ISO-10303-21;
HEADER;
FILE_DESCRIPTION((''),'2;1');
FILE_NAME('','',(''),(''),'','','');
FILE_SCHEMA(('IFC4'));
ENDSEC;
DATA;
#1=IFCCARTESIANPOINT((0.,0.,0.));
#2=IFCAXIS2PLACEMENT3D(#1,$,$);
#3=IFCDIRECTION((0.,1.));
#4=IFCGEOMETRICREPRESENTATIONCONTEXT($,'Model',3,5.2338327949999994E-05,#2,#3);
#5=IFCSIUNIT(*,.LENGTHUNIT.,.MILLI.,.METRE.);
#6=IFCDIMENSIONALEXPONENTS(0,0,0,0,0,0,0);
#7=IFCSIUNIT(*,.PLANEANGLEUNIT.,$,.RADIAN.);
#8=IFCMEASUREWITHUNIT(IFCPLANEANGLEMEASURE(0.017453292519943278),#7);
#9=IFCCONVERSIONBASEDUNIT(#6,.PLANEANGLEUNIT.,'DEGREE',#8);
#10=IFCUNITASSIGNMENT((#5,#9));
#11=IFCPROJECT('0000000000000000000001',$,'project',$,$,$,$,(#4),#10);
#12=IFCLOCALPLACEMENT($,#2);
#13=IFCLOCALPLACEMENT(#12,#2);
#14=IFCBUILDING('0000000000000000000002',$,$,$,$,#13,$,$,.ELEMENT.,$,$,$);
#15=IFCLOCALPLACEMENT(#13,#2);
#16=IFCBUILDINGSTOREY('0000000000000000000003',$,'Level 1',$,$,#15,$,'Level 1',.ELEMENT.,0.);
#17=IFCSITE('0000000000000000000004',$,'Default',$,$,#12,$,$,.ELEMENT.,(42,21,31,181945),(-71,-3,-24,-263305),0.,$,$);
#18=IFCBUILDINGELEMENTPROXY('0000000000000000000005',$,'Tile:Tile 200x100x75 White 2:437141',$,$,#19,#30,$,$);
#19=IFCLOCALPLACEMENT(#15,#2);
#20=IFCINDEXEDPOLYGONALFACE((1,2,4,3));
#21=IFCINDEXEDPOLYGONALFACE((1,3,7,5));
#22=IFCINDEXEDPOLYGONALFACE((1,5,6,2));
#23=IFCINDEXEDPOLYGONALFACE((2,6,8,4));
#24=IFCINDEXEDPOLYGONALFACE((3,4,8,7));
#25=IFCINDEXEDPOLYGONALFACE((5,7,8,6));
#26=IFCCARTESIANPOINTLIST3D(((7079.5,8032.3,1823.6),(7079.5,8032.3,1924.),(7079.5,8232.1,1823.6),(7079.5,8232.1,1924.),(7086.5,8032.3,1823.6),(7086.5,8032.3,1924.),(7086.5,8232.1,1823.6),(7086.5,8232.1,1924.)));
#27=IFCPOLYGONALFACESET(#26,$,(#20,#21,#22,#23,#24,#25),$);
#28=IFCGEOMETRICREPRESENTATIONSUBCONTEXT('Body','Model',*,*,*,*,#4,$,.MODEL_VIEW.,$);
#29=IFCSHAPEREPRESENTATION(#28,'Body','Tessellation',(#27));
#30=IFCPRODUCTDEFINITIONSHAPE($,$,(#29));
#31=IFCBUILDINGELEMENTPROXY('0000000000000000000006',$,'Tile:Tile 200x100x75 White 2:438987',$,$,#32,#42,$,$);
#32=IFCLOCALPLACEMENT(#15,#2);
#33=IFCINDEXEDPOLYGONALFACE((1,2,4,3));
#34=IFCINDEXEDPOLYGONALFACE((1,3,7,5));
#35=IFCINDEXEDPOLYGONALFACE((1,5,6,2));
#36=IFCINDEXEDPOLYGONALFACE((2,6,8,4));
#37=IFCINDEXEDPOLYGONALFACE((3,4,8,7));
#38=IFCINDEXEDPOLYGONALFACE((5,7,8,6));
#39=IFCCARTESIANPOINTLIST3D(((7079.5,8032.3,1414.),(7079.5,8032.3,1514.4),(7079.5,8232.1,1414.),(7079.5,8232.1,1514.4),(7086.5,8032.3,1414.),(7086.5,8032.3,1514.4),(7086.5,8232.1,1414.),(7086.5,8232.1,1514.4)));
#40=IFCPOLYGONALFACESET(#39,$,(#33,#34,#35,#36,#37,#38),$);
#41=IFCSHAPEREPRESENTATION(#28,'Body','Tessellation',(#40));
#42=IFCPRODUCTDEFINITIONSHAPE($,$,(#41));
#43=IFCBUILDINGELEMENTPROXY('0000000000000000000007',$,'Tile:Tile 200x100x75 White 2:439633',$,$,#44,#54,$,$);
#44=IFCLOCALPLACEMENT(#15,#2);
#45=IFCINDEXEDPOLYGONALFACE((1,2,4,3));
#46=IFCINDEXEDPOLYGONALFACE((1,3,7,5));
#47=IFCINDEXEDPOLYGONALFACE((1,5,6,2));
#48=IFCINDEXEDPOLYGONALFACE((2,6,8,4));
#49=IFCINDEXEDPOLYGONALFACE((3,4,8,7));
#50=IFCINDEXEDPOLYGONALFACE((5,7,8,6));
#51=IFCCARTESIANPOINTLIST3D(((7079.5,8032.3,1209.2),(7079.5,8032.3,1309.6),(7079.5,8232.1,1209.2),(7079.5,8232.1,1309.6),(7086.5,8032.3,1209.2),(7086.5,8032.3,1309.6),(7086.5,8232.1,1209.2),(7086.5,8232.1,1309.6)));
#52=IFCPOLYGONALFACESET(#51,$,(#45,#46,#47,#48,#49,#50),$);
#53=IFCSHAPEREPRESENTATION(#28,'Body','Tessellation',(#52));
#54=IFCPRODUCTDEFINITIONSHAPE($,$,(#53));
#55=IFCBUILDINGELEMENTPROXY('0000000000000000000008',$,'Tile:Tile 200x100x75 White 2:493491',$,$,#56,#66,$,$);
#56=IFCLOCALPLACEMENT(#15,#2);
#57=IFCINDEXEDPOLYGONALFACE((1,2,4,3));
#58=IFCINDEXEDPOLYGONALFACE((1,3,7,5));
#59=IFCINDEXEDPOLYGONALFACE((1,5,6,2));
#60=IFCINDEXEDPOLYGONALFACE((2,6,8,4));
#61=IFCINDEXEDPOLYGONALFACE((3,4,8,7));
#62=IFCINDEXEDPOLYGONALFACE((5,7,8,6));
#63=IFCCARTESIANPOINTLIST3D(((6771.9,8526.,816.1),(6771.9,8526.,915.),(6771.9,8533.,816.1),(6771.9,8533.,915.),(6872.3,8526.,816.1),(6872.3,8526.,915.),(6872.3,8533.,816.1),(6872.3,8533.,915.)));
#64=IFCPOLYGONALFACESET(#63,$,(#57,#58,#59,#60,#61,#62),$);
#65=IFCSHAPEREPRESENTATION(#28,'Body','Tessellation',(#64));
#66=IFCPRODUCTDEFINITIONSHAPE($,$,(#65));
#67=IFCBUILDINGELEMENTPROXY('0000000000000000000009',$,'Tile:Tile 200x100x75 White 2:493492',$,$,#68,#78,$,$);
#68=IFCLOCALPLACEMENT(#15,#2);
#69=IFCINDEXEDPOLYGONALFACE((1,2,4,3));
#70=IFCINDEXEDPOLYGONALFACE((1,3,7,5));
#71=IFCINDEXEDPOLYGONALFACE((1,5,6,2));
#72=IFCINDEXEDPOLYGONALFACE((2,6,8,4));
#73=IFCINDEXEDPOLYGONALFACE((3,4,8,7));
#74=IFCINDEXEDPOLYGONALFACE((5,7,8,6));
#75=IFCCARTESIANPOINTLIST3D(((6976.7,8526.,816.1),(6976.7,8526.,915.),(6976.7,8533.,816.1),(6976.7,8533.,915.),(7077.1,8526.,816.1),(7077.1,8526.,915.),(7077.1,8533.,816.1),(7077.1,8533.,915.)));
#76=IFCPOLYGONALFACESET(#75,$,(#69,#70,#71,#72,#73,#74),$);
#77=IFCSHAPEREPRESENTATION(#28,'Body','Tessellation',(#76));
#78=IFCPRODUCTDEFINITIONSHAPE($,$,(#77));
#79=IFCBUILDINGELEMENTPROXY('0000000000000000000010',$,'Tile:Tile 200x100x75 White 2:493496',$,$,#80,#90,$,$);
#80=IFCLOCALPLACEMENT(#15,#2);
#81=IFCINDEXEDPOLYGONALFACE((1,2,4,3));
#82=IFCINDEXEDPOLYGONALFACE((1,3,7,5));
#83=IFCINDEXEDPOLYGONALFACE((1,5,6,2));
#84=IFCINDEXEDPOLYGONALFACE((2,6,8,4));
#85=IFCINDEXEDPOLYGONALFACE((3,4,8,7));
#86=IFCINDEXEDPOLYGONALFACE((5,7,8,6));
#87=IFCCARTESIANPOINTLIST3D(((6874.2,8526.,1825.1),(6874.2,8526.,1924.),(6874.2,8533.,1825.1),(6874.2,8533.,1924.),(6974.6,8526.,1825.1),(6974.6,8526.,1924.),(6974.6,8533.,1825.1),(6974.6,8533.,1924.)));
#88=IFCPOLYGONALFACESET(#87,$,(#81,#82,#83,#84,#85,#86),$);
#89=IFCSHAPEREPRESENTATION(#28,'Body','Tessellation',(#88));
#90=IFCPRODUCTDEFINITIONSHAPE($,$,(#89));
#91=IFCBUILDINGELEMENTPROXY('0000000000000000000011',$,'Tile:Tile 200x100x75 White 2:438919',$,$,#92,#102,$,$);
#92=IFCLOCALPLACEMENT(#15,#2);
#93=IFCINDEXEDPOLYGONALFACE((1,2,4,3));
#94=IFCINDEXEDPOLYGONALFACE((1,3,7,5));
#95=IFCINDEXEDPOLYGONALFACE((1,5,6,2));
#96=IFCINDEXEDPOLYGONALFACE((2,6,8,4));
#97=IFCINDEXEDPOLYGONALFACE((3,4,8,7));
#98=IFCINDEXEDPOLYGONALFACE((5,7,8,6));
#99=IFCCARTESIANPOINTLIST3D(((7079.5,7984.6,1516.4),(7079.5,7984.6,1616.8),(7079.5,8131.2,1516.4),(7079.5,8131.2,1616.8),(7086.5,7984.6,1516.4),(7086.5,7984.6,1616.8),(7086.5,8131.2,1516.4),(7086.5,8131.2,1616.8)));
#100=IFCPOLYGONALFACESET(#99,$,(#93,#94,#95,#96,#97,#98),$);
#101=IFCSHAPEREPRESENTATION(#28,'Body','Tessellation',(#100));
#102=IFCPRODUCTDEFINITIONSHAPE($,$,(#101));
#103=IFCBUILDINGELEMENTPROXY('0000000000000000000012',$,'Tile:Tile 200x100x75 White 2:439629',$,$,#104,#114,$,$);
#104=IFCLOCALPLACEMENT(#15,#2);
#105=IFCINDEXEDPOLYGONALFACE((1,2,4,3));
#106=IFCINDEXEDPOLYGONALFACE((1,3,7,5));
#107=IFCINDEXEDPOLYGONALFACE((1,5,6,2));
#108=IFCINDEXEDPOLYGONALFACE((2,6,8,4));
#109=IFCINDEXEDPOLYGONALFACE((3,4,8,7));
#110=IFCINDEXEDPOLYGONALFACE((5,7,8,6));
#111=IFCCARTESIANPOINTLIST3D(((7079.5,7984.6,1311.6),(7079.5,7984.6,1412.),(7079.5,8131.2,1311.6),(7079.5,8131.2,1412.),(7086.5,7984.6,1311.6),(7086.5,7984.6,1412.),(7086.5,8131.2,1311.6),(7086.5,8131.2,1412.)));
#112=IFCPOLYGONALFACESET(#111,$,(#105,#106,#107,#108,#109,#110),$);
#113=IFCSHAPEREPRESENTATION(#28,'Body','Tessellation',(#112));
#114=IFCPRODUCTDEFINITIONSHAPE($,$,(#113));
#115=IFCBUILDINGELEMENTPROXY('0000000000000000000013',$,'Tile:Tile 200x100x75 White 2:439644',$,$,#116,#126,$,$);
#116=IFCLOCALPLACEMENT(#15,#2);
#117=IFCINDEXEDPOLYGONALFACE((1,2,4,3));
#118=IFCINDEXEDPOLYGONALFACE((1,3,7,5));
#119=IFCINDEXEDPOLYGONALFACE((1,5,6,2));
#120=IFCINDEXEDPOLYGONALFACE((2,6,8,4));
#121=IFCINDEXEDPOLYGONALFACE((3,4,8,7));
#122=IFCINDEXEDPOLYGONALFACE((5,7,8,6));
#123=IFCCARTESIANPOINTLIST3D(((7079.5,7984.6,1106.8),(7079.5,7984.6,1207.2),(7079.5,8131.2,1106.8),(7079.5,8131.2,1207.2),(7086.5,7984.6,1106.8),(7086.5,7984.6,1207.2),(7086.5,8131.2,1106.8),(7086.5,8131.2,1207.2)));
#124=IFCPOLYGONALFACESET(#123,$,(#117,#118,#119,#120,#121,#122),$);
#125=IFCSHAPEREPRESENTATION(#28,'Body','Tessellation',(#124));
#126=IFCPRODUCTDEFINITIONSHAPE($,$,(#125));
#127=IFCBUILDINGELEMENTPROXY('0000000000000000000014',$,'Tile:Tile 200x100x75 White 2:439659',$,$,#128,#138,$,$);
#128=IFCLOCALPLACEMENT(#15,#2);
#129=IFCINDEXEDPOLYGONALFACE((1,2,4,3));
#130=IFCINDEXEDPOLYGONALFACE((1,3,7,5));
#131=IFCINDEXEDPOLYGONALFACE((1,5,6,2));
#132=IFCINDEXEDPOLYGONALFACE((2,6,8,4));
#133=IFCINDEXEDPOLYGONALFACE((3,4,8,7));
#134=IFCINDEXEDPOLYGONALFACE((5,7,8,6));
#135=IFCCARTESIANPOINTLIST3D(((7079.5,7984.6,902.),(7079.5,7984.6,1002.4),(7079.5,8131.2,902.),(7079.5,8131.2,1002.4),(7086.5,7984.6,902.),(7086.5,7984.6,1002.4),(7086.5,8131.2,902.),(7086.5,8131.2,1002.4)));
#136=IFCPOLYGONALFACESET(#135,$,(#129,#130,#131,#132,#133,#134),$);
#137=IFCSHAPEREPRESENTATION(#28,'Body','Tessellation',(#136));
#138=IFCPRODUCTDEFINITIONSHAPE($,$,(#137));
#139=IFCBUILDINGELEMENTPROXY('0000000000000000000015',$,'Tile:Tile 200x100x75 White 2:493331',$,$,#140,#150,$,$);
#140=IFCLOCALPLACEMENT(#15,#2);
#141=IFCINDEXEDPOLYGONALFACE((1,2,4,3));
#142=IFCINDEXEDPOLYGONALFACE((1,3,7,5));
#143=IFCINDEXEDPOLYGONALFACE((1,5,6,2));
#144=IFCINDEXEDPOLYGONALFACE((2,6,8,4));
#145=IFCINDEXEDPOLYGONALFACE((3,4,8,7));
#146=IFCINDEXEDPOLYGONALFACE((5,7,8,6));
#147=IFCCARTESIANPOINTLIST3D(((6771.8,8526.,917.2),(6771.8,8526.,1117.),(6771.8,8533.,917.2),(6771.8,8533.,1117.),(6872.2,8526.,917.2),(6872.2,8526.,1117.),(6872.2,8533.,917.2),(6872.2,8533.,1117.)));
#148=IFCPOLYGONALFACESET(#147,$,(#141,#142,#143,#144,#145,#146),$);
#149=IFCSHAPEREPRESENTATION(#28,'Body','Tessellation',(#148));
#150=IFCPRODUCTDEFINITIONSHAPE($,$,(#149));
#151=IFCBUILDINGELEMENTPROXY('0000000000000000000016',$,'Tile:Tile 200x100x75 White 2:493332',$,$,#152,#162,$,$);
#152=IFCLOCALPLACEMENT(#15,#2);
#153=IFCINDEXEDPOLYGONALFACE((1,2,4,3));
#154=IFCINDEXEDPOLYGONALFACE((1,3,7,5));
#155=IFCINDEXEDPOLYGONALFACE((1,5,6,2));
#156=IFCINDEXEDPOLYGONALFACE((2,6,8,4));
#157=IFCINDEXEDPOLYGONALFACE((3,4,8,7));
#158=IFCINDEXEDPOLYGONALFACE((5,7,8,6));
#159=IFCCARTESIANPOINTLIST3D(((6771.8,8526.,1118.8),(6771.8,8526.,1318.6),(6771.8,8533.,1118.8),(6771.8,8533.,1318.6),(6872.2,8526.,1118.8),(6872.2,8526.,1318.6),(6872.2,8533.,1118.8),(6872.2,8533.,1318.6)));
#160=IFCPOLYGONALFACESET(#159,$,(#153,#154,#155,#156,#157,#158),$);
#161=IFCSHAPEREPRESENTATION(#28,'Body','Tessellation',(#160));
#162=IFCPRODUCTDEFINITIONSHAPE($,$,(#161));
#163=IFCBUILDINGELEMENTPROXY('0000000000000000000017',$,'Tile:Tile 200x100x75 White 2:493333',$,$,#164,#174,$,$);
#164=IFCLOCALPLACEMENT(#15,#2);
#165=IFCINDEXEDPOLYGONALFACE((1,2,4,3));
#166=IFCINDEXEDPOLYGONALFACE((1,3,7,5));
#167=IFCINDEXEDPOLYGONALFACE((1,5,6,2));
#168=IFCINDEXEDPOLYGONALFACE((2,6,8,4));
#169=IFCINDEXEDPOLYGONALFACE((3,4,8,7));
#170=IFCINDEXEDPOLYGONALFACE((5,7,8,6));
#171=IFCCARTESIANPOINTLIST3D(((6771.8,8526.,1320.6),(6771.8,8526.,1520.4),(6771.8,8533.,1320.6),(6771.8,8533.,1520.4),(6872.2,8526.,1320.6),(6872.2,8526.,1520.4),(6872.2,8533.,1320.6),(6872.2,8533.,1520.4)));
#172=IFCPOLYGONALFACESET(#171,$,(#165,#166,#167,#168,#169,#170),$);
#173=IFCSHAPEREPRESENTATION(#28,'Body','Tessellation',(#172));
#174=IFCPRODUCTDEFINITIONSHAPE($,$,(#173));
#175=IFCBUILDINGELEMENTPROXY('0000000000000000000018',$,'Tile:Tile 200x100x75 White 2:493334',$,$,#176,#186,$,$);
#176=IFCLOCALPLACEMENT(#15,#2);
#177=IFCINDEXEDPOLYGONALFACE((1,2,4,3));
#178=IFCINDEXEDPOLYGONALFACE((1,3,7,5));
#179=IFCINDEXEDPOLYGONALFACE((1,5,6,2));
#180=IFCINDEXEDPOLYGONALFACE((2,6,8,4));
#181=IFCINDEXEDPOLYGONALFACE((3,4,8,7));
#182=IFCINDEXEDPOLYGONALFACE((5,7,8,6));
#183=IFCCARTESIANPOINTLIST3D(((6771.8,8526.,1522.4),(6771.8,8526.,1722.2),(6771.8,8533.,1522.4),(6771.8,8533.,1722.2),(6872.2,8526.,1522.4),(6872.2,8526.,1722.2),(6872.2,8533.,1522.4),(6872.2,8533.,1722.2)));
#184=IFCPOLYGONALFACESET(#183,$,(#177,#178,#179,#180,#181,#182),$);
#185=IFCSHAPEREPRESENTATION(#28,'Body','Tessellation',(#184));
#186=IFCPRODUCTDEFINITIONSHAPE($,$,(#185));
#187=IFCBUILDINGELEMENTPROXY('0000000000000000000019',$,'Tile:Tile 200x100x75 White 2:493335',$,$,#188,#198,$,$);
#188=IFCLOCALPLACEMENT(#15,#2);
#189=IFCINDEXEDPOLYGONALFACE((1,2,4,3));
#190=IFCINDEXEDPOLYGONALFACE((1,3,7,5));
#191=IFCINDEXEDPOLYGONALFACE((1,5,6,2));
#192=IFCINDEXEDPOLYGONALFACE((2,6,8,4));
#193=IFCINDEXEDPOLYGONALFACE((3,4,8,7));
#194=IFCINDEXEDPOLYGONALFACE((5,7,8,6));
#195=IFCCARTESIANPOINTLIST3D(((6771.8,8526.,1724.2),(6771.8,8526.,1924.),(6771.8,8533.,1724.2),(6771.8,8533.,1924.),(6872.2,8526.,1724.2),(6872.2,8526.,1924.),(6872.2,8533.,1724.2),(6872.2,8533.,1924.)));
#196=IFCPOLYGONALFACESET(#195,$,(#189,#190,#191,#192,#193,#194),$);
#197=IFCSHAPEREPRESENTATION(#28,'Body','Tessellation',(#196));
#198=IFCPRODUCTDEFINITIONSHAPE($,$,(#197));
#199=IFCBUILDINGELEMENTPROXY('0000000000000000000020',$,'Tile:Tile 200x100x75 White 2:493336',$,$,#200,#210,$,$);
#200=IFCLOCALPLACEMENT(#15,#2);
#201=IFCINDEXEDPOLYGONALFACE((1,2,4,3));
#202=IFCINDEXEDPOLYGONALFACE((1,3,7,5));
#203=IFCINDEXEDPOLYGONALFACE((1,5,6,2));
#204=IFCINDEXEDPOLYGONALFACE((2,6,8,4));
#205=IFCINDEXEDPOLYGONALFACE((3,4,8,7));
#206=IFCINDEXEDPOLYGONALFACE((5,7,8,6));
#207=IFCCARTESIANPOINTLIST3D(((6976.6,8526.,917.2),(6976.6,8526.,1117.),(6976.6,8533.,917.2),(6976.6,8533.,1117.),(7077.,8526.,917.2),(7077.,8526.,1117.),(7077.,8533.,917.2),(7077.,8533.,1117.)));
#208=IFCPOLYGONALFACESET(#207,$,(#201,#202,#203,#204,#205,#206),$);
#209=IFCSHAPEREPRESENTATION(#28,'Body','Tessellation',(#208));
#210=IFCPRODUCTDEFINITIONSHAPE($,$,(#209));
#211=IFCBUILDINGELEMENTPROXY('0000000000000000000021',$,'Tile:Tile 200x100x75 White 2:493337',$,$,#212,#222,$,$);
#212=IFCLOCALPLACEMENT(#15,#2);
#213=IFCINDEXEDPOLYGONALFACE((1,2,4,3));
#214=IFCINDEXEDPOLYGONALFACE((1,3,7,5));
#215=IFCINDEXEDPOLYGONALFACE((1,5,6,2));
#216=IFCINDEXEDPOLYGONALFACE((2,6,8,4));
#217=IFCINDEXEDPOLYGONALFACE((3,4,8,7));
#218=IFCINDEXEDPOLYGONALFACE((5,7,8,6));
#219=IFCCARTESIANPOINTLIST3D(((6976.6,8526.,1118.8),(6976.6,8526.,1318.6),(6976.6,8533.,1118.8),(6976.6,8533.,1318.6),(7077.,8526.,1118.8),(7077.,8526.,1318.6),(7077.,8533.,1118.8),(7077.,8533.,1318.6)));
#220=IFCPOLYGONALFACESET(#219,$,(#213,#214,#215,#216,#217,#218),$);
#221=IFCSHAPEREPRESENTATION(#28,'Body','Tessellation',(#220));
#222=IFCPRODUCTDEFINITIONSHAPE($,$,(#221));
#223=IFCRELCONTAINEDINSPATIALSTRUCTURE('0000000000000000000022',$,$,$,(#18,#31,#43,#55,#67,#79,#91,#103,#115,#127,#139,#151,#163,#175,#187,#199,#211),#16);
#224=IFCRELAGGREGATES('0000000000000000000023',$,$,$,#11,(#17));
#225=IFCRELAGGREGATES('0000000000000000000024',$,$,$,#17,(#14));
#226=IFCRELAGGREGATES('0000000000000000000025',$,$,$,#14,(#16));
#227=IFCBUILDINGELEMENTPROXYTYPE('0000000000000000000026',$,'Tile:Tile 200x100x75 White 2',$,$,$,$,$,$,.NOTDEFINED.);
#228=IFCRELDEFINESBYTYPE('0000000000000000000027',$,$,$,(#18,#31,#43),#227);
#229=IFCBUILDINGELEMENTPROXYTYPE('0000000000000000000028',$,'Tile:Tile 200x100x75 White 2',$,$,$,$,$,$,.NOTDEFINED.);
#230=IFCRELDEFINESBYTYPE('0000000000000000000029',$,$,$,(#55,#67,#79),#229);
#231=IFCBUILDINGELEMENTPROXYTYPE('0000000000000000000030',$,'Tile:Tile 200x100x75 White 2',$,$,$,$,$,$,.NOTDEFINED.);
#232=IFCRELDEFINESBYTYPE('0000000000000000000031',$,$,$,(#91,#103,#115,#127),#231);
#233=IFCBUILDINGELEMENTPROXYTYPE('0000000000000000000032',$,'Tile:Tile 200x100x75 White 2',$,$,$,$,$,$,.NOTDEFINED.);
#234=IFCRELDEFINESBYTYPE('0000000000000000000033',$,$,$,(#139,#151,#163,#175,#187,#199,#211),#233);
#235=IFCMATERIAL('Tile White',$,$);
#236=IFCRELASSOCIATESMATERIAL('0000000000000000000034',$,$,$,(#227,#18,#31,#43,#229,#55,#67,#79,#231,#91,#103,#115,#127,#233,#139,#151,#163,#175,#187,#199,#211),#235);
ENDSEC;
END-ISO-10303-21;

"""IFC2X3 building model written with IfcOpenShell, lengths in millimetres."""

from ifc_helpers import new_model, entity, si_unit, converted_unit, direction, frame, frame_2d, origin, origin_2d_with_axis, place, context, subcontext, project, spatial, rectangle, extrude, source, transform, mapped, material, type_object, type_shapes, element, save


model = new_model("IFC2X3")

# Units and contexts
model_context = context("Model", 3, precision=5.2338327949999994e-05, world=origin(), true_north=direction((0.0, 1.0)))
body_context = subcontext(model_context, "Body", "Model", "MODEL_VIEW")
ifc_project = project(units=[si_unit("LENGTHUNIT", "METRE", prefix="MILLI"), converted_unit("PLANEANGLEUNIT", "DEGREE", entity("IfcPlaneAngleMeasure", 0.017453292519943278), si_unit("PLANEANGLEUNIT", "RADIAN"), dimensions=[0, 0, 0, 0, 0, 0, 0])], contexts=[model_context])

# Site, building, storey
site_placement = place(None, origin())
site = spatial("IfcSite", under=ifc_project, at=site_placement, Name="Default", CompositionType="ELEMENT", RefLatitude=(42, 21, 31, 181945), RefLongitude=(-71, -3, -24, -263305), RefElevation=0.0)
building_placement = place(site_placement, origin())
building = spatial("IfcBuilding", under=site, at=building_placement, CompositionType="ELEMENT")
storey_placement = place(building_placement, origin())
storey = spatial("IfcBuildingStorey", under=building, at=storey_placement, Name="Level 1", LongName="Level 1", CompositionType="ELEMENT", Elevation=0.0)

# Building element proxies
ifc_material = material(Name="Tile White")
building_element_proxy_type_1 = type_object("IfcBuildingElementProxyType", Name="Tile:Tile 200x100x75 White 2", PredefinedType="NOTDEFINED", material=ifc_material)
shared_shape_1 = source(origin(), body_context, "Body", "SweptSolid", [
    extrude(rectangle(XDim=199.8, YDim=100.4, at=frame_2d((0.0, 0.0), x_axis=(1.0, 0.0))), frame((-50.2, -99.9, 0.0), z_axis=(0.0, 0.0, 1.0), x_axis=(0.0, -1.0, 0.0)), (0.0, 0.0, 1.0), 7.0),
])
type_shapes(building_element_proxy_type_1, [shared_shape_1])
for number, where, z_axis, x_axis, name in (
    (1, (7086.5, 8232.1, 1924.0), (-1.0, 0.0, 0.0), (0.0, 0.0, 1.0), "Tile:Tile 200x100x75 White 2:437141"),
    (2, (7086.5, 8232.1, 1514.4), (-1.0, 0.0, 0.0), (0.0, 0.0, 1.0), "Tile:Tile 200x100x75 White 2:438987"),
    (3, (7086.5, 8232.1, 1309.6), (-1.0, 0.0, 0.0), (0.0, 0.0, 1.0), "Tile:Tile 200x100x75 White 2:439633"),
):
    element("IfcBuildingElementProxy", number, at=place(storey_placement, frame(where, z_axis=z_axis, x_axis=x_axis)), inside=storey, type_object=building_element_proxy_type_1, material=ifc_material, Name=name, context=body_context, shape_type="MappedRepresentation", body=[
        mapped(shared_shape_1, transform((0.0, 0.0, 0.0), scale=1.0)),
    ])
building_element_proxy_type_2 = type_object("IfcBuildingElementProxyType", Name="Tile:Tile 200x100x75 White 2", PredefinedType="NOTDEFINED", material=ifc_material)
shared_shape_2 = source(origin(), body_context, "Body", "SweptSolid", [
    extrude(rectangle(XDim=98.9, YDim=100.4, at=origin_2d_with_axis()), frame((-50.2, -49.5, 0.0), z_axis=(0.0, 0.0, 1.0), x_axis=(0.0, -1.0, 0.0)), (0.0, 0.0, 1.0), 7.0),
])
type_shapes(building_element_proxy_type_2, [shared_shape_2])
for number, where, z_axis, x_axis, name in (
    (4, (6872.3, 8533.0, 915.0), (0.0, -1.0, 0.0), (1.0, 0.0, 0.0), "Tile:Tile 200x100x75 White 2:493491"),
    (5, (7077.1, 8533.0, 915.0), (0.0, -1.0, 0.0), (1.0, 0.0, 0.0), "Tile:Tile 200x100x75 White 2:493492"),
    (6, (6974.6, 8533.0, 1924.0), (0.0, -1.0, 0.0), (1.0, 0.0, 0.0), "Tile:Tile 200x100x75 White 2:493496"),
):
    element("IfcBuildingElementProxy", number, at=place(storey_placement, frame(where, z_axis=z_axis, x_axis=x_axis)), inside=storey, type_object=building_element_proxy_type_2, material=ifc_material, Name=name, context=body_context, shape_type="MappedRepresentation", body=[
        mapped(shared_shape_2, transform((0.0, 0.0, 0.0), scale=1.0)),
    ])
building_element_proxy_type_3 = type_object("IfcBuildingElementProxyType", Name="Tile:Tile 200x100x75 White 2", PredefinedType="NOTDEFINED", material=ifc_material)
shared_shape_3 = source(origin(), body_context, "Body", "SweptSolid", [
    extrude(rectangle(XDim=146.6, YDim=100.4, at=origin_2d_with_axis()), frame((-50.2, -73.3, 0.0), z_axis=(0.0, 0.0, 1.0), x_axis=(0.0, -1.0, 0.0)), (0.0, 0.0, 1.0), 7.0),
])
type_shapes(building_element_proxy_type_3, [shared_shape_3])
for number, where, z_axis, x_axis, name in (
    (7, (7086.5, 8131.2, 1616.8), (-1.0, 0.0, 0.0), (0.0, 0.0, 1.0), "Tile:Tile 200x100x75 White 2:438919"),
    (8, (7086.5, 8131.2, 1412.0), (-1.0, 0.0, 0.0), (0.0, 0.0, 1.0), "Tile:Tile 200x100x75 White 2:439629"),
    (9, (7086.5, 8131.2, 1207.2), (-1.0, 0.0, 0.0), (0.0, 0.0, 1.0), "Tile:Tile 200x100x75 White 2:439644"),
    (10, (7086.5, 8131.2, 1002.4), (-1.0, 0.0, 0.0), (0.0, 0.0, 1.0), "Tile:Tile 200x100x75 White 2:439659"),
):
    element("IfcBuildingElementProxy", number, at=place(storey_placement, frame(where, z_axis=z_axis, x_axis=x_axis)), inside=storey, type_object=building_element_proxy_type_3, material=ifc_material, Name=name, context=body_context, shape_type="MappedRepresentation", body=[
        mapped(shared_shape_3, transform((0.0, 0.0, 0.0), scale=1.0)),
    ])
building_element_proxy_type_4 = type_object("IfcBuildingElementProxyType", Name="Tile:Tile 200x100x75 White 2", PredefinedType="NOTDEFINED", material=ifc_material)
shared_shape_4 = source(origin(), body_context, "Body", "SweptSolid", [
    extrude(rectangle(XDim=199.8, YDim=100.4, at=frame_2d((0.0, 0.0), x_axis=(1.0, 0.0))), frame((-50.2, -99.9, 0.0), z_axis=(0.0, 0.0, 1.0), x_axis=(0.0, -1.0, 0.0)), (0.0, 0.0, 1.0), 7.0),
])
type_shapes(building_element_proxy_type_4, [shared_shape_4])
for number, where, z_axis, x_axis, name in (
    (11, (6872.2, 8533.0, 1117.0), (0.0, -1.0, 0.0), (1.0, 0.0, 0.0), "Tile:Tile 200x100x75 White 2:493331"),
    (12, (6872.2, 8533.0, 1318.6), (0.0, -1.0, 0.0), (1.0, 0.0, 0.0), "Tile:Tile 200x100x75 White 2:493332"),
    (13, (6872.2, 8533.0, 1520.4), (0.0, -1.0, 0.0), (1.0, 0.0, 0.0), "Tile:Tile 200x100x75 White 2:493333"),
    (14, (6872.2, 8533.0, 1722.2), (0.0, -1.0, 0.0), (1.0, 0.0, 0.0), "Tile:Tile 200x100x75 White 2:493334"),
    (15, (6872.2, 8533.0, 1924.0), (0.0, -1.0, 0.0), (1.0, 0.0, 0.0), "Tile:Tile 200x100x75 White 2:493335"),
    (16, (7077.0, 8533.0, 1117.0), (0.0, -1.0, 0.0), (1.0, 0.0, 0.0), "Tile:Tile 200x100x75 White 2:493336"),
    (17, (7077.0, 8533.0, 1318.6), (0.0, -1.0, 0.0), (1.0, 0.0, 0.0), "Tile:Tile 200x100x75 White 2:493337"),
):
    element("IfcBuildingElementProxy", number, at=place(storey_placement, frame(where, z_axis=z_axis, x_axis=x_axis)), inside=storey, type_object=building_element_proxy_type_4, material=ifc_material, Name=name, context=body_context, shape_type="MappedRepresentation", body=[
        mapped(shared_shape_4, transform((0.0, 0.0, 0.0), scale=1.0)),
    ])

save(model, "model.ifc")
